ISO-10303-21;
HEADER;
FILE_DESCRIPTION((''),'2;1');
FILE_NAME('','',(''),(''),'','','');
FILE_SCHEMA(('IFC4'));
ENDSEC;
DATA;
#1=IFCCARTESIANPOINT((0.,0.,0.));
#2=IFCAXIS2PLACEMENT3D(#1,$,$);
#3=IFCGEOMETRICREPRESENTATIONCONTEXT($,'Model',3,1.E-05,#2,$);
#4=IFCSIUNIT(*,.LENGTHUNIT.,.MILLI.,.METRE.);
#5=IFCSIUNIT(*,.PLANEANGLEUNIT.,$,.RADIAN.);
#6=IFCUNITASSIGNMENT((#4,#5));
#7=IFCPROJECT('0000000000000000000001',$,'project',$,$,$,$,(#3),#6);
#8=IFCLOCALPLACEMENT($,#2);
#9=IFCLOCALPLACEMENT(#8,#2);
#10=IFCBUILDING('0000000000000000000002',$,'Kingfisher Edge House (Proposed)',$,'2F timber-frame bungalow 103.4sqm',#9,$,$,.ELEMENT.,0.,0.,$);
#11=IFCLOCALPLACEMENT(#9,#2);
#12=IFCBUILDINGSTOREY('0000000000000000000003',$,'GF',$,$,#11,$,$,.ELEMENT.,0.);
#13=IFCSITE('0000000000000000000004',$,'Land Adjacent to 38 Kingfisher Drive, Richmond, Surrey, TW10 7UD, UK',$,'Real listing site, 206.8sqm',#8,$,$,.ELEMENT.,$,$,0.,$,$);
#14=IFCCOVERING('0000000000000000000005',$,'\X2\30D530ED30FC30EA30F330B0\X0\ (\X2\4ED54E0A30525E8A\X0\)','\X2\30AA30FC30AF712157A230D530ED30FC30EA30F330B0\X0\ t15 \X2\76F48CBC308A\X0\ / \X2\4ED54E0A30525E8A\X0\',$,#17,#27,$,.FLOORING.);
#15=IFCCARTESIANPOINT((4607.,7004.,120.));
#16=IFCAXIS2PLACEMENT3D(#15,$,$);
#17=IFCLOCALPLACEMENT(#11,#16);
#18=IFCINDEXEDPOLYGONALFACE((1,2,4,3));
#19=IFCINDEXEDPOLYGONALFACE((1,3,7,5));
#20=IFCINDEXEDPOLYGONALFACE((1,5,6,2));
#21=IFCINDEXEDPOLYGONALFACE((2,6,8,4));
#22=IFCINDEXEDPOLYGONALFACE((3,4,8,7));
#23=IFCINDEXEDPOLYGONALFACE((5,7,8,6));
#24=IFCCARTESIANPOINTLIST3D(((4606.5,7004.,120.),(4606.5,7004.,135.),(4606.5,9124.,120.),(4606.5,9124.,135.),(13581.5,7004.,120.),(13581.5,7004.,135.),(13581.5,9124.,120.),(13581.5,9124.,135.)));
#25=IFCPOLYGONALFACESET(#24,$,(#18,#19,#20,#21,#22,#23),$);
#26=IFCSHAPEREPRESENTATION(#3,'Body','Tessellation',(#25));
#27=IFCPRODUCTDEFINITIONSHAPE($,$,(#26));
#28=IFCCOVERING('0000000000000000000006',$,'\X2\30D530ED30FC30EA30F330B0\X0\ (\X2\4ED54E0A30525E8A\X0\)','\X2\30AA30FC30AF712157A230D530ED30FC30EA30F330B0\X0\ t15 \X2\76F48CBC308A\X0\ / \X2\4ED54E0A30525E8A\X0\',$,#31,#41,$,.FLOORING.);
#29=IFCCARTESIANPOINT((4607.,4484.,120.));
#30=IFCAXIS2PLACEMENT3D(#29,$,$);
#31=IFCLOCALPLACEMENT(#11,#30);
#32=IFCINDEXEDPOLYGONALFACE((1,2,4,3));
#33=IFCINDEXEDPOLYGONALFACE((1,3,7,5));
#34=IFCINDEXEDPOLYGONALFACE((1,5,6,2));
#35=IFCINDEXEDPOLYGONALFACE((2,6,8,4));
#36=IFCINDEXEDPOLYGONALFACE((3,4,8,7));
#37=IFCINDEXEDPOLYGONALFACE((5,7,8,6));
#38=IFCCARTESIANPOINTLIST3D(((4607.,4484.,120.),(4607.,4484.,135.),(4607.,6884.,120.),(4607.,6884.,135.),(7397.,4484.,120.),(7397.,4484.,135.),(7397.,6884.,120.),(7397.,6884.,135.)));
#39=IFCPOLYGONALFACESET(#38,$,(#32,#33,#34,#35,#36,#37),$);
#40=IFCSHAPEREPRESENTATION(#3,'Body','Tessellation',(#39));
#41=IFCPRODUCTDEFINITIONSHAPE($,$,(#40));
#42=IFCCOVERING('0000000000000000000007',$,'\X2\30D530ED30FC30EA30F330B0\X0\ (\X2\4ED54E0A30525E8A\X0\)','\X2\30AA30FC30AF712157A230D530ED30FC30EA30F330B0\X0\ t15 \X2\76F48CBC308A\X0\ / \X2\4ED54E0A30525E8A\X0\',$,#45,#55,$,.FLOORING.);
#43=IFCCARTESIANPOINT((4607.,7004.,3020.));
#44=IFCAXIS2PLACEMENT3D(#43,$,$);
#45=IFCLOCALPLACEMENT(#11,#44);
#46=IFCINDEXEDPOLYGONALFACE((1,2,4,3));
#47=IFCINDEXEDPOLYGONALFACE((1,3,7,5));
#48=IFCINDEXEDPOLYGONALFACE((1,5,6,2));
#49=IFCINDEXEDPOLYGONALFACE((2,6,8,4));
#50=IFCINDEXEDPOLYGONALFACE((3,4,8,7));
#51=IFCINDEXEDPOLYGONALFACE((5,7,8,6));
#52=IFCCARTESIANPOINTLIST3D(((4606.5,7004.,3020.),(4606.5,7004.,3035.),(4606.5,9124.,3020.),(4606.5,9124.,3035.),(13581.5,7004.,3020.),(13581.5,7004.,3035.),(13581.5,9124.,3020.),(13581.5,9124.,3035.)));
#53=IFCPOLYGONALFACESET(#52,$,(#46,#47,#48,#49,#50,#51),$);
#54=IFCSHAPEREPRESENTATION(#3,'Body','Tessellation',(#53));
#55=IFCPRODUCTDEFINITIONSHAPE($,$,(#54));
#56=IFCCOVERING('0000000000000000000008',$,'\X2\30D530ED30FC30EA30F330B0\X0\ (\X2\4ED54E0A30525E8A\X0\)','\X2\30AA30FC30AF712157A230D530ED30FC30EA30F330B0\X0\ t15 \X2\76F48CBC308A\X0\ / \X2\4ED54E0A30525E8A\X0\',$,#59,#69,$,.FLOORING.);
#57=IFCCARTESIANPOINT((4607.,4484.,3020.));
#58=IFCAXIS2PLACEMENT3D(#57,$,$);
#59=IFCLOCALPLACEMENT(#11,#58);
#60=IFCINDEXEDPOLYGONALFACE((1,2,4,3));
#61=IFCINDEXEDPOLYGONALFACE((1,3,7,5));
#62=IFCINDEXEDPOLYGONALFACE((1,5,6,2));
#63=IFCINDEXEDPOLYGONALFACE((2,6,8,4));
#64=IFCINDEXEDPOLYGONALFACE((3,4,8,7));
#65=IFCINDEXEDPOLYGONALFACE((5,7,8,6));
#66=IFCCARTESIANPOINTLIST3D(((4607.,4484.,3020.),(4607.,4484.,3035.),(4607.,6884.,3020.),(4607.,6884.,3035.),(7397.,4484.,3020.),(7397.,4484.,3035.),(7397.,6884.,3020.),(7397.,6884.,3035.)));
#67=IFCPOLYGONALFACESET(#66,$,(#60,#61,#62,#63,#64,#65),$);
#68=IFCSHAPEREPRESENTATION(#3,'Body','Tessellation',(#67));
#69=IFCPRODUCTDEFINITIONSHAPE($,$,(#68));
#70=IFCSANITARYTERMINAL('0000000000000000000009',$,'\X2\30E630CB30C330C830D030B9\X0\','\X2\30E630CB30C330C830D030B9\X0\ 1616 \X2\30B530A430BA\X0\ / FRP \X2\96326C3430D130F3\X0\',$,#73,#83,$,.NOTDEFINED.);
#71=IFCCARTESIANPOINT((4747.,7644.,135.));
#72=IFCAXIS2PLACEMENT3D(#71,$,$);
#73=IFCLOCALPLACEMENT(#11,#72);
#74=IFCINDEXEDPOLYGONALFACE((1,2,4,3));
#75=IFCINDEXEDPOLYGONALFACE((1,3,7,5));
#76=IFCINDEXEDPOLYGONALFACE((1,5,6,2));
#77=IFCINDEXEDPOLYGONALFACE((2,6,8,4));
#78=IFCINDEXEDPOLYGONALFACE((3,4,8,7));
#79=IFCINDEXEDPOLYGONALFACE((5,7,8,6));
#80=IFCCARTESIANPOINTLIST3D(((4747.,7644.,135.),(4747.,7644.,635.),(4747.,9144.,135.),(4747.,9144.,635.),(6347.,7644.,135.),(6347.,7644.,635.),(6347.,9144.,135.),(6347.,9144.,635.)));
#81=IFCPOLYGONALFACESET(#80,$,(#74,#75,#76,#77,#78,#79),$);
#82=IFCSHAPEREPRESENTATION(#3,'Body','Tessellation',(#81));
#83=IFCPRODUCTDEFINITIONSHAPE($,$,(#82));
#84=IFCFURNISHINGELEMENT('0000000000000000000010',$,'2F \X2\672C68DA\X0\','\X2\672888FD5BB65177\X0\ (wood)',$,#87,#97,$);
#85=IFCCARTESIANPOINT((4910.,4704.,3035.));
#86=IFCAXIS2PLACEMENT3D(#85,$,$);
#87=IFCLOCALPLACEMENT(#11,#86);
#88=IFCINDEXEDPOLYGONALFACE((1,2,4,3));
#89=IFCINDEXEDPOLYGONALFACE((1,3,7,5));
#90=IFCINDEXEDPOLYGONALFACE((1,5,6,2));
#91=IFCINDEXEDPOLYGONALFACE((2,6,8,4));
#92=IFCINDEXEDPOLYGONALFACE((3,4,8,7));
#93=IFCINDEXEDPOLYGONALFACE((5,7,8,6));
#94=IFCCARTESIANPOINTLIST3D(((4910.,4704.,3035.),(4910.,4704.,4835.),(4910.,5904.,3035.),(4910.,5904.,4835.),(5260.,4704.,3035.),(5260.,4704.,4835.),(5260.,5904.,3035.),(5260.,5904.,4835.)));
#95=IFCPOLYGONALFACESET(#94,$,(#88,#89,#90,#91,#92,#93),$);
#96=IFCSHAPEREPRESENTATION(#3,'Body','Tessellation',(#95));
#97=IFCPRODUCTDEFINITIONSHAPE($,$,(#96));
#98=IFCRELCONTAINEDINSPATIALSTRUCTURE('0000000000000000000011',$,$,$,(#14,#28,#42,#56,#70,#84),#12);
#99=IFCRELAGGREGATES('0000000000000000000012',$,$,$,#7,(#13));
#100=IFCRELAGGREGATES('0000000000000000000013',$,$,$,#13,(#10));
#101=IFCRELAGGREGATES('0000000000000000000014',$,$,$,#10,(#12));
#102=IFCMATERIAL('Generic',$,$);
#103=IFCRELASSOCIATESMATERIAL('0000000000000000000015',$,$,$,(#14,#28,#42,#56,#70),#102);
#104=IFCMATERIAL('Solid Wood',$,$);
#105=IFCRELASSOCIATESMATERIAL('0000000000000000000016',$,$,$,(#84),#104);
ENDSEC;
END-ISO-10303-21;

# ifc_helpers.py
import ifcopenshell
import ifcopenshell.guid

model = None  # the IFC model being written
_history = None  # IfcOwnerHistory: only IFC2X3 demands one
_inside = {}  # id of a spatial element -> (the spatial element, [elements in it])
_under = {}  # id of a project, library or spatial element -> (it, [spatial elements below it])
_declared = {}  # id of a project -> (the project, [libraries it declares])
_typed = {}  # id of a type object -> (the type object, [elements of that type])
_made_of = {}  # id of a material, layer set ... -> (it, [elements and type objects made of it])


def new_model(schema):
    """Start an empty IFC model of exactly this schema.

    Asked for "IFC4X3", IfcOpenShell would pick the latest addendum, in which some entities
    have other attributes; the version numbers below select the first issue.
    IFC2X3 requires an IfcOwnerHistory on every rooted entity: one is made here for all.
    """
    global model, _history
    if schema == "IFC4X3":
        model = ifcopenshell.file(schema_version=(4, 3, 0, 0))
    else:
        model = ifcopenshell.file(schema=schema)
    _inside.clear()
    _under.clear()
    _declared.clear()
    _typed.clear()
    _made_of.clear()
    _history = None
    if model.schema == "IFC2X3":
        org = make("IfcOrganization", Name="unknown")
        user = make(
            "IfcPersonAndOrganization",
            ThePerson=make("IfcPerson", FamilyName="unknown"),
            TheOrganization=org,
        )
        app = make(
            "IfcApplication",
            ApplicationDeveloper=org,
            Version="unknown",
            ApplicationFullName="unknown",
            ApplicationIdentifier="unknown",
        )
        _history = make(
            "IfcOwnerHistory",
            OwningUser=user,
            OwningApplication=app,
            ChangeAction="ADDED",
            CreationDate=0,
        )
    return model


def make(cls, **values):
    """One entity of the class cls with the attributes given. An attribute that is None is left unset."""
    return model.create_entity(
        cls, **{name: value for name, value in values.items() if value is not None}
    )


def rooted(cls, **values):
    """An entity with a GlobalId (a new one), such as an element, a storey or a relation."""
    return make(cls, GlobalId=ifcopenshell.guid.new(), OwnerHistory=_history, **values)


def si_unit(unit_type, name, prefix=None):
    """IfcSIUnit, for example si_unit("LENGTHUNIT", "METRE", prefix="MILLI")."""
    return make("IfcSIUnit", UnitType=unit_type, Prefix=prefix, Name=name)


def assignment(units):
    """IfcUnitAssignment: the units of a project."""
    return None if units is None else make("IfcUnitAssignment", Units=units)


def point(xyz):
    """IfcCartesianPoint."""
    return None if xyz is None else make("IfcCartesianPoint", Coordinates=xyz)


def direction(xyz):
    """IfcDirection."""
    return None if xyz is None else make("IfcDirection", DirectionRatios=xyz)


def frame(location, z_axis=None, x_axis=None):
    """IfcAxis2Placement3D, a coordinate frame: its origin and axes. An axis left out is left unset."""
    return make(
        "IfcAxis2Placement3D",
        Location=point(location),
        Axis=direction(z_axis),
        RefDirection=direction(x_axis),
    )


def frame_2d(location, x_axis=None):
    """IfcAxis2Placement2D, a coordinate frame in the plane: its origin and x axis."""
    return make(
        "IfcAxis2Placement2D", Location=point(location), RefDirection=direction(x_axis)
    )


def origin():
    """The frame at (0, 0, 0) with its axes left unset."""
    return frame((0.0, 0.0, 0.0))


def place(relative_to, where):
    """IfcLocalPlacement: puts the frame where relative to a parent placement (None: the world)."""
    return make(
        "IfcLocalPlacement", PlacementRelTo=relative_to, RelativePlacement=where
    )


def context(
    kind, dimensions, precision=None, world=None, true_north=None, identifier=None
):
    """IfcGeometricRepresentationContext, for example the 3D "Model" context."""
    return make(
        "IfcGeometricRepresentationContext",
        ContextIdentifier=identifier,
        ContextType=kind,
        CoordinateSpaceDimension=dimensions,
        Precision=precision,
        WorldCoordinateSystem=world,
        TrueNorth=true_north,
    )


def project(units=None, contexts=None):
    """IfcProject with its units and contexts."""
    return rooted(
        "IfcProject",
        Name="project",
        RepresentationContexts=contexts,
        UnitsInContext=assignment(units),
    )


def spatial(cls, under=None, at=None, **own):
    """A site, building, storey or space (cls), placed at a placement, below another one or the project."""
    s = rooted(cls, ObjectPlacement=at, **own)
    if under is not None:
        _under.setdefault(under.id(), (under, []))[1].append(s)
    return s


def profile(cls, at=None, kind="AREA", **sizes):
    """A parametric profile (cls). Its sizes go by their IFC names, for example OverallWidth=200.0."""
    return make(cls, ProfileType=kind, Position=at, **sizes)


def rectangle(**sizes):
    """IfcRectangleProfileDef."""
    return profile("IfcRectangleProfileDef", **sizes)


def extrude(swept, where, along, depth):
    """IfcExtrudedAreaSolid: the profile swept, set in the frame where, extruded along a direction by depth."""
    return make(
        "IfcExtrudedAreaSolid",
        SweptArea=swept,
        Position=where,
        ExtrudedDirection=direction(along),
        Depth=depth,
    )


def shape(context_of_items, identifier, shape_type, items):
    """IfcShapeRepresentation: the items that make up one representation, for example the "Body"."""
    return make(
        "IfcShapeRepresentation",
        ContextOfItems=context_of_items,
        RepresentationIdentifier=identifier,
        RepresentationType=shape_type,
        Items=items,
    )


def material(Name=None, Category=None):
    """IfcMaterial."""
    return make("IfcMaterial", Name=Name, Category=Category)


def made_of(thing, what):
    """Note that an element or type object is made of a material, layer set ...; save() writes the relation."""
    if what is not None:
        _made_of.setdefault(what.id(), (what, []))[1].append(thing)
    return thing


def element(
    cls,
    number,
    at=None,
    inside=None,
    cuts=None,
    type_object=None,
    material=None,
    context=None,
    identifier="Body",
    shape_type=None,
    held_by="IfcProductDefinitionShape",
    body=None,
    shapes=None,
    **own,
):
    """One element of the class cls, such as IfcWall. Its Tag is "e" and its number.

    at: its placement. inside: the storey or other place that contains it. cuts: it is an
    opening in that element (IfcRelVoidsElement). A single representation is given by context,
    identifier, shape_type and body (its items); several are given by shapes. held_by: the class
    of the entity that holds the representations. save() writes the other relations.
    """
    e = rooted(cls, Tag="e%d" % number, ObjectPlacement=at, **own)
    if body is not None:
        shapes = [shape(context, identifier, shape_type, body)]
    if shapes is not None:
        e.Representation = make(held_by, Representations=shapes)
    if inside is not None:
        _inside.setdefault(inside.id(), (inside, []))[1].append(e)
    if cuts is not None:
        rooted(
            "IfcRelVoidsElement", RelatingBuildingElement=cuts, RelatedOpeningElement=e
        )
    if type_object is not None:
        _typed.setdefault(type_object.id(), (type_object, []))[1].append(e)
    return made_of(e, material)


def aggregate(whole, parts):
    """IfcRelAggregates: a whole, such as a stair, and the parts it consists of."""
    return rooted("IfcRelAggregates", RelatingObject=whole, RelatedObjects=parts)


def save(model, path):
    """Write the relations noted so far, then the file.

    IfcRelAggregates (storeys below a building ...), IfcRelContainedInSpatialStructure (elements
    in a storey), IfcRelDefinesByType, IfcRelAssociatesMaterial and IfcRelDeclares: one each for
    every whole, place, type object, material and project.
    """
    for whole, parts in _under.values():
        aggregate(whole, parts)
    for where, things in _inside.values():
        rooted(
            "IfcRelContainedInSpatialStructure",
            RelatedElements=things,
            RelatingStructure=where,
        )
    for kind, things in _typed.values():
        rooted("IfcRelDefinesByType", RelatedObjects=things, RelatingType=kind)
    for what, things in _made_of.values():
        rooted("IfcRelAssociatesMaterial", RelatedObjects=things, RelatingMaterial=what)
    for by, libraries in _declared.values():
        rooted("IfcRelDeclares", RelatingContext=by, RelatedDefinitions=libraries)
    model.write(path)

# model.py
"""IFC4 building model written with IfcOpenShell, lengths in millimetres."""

from ifc_helpers import new_model, si_unit, frame, frame_2d, origin, place, context, project, spatial, rectangle, extrude, material, element, save


model = new_model("IFC4")

# Units and contexts
model_context = context("Model", 3, precision=1e-05, world=origin())
ifc_project = project(units=[si_unit("LENGTHUNIT", "METRE", prefix="MILLI"), si_unit("PLANEANGLEUNIT", "RADIAN")], contexts=[model_context])

# Site, building, storey
site_placement = place(None, origin())
site = spatial("IfcSite", under=ifc_project, at=site_placement, Name="Land Adjacent to 38 Kingfisher Drive, Richmond, Surrey, TW10 7UD, UK", ObjectType="Real listing site, 206.8sqm", CompositionType="ELEMENT", RefElevation=0.0)
building_placement = place(site_placement, origin())
building = spatial("IfcBuilding", under=site, at=building_placement, Name="Kingfisher Edge House (Proposed)", ObjectType="2F timber-frame bungalow 103.4sqm", CompositionType="ELEMENT", ElevationOfRefHeight=0.0, ElevationOfTerrain=0.0)
storey_placement = place(building_placement, origin())
storey = spatial("IfcBuildingStorey", under=building, at=storey_placement, Name="GF", CompositionType="ELEMENT", Elevation=0.0)

# Shared definitions
ifc_material_1 = material(Name="Solid Wood")

# Coverings
ifc_material_2 = material(Name="Generic")
covering_1_placement = place(storey_placement, frame((4607.0, 7004.0, 120.0)))
element("IfcCovering", 1, at=covering_1_placement, inside=storey, material=ifc_material_2, Name="フローリング (仕上げ床)", Description="オーク無垢フローリング t15 直貼り / 仕上げ床", PredefinedType="FLOORING", context=model_context, shape_type="SweptSolid", body=[
    extrude(rectangle(XDim=8975.0, YDim=2120.0, at=frame_2d((4487.0, 1060.0))), frame((4607.0, 7004.0, 120.0)), (0.0, 0.0, 1.0), 15.0),
])
covering_2_placement = place(storey_placement, frame((4607.0, 4484.0, 120.0)))
element("IfcCovering", 2, at=covering_2_placement, inside=storey, material=ifc_material_2, Name="フローリング (仕上げ床)", Description="オーク無垢フローリング t15 直貼り / 仕上げ床", PredefinedType="FLOORING", context=model_context, shape_type="SweptSolid", body=[
    extrude(rectangle(XDim=2790.0, YDim=2400.0, at=frame_2d((1395.0, 1200.0))), frame((4607.0, 4484.0, 120.0)), (0.0, 0.0, 1.0), 15.0),
])
covering_3_placement = place(storey_placement, frame((4607.0, 7004.0, 3020.0)))
element("IfcCovering", 3, at=covering_3_placement, inside=storey, material=ifc_material_2, Name="フローリング (仕上げ床)", Description="オーク無垢フローリング t15 直貼り / 仕上げ床", PredefinedType="FLOORING", context=model_context, shape_type="SweptSolid", body=[
    extrude(rectangle(XDim=8975.0, YDim=2120.0, at=frame_2d((4487.0, 1060.0))), frame((4607.0, 7004.0, 3020.0)), (0.0, 0.0, 1.0), 15.0),
])
covering_4_placement = place(storey_placement, frame((4607.0, 4484.0, 3020.0)))
element("IfcCovering", 4, at=covering_4_placement, inside=storey, material=ifc_material_2, Name="フローリング (仕上げ床)", Description="オーク無垢フローリング t15 直貼り / 仕上げ床", PredefinedType="FLOORING", context=model_context, shape_type="SweptSolid", body=[
    extrude(rectangle(XDim=2790.0, YDim=2400.0, at=frame_2d((1395.0, 1200.0))), frame((4607.0, 4484.0, 3020.0)), (0.0, 0.0, 1.0), 15.0),
])

# Sanitary terminal
sanitary_terminal_placement = place(storey_placement, frame((4747.0, 7644.0, 135.0)))
element("IfcSanitaryTerminal", 5, at=sanitary_terminal_placement, inside=storey, material=ifc_material_2, Name="ユニットバス", Description="ユニットバス 1616 サイズ / FRP 防水パン", PredefinedType="NOTDEFINED", context=model_context, shape_type="SweptSolid", body=[
    extrude(rectangle(XDim=1600.0, YDim=1500.0, at=frame_2d((800.0, 750.0))), frame((4747.0, 7644.0, 135.0)), (0.0, 0.0, 1.0), 500.0),
])

# Furnishing element
furnishing_placement = place(storey_placement, frame((4910.0, 4704.0, 3035.0)))
element("IfcFurnishingElement", 6, at=furnishing_placement, inside=storey, material=ifc_material_1, Name="2F 本棚", Description="木製家具 (wood)", context=model_context, shape_type="SweptSolid", body=[
    extrude(rectangle(XDim=350.0, YDim=1200.0, at=frame_2d((175.0, 600.0))), frame((4910.0, 4704.0, 3035.0)), (0.0, 0.0, 1.0), 1800.0),
])

save(model, "model.ifc")
